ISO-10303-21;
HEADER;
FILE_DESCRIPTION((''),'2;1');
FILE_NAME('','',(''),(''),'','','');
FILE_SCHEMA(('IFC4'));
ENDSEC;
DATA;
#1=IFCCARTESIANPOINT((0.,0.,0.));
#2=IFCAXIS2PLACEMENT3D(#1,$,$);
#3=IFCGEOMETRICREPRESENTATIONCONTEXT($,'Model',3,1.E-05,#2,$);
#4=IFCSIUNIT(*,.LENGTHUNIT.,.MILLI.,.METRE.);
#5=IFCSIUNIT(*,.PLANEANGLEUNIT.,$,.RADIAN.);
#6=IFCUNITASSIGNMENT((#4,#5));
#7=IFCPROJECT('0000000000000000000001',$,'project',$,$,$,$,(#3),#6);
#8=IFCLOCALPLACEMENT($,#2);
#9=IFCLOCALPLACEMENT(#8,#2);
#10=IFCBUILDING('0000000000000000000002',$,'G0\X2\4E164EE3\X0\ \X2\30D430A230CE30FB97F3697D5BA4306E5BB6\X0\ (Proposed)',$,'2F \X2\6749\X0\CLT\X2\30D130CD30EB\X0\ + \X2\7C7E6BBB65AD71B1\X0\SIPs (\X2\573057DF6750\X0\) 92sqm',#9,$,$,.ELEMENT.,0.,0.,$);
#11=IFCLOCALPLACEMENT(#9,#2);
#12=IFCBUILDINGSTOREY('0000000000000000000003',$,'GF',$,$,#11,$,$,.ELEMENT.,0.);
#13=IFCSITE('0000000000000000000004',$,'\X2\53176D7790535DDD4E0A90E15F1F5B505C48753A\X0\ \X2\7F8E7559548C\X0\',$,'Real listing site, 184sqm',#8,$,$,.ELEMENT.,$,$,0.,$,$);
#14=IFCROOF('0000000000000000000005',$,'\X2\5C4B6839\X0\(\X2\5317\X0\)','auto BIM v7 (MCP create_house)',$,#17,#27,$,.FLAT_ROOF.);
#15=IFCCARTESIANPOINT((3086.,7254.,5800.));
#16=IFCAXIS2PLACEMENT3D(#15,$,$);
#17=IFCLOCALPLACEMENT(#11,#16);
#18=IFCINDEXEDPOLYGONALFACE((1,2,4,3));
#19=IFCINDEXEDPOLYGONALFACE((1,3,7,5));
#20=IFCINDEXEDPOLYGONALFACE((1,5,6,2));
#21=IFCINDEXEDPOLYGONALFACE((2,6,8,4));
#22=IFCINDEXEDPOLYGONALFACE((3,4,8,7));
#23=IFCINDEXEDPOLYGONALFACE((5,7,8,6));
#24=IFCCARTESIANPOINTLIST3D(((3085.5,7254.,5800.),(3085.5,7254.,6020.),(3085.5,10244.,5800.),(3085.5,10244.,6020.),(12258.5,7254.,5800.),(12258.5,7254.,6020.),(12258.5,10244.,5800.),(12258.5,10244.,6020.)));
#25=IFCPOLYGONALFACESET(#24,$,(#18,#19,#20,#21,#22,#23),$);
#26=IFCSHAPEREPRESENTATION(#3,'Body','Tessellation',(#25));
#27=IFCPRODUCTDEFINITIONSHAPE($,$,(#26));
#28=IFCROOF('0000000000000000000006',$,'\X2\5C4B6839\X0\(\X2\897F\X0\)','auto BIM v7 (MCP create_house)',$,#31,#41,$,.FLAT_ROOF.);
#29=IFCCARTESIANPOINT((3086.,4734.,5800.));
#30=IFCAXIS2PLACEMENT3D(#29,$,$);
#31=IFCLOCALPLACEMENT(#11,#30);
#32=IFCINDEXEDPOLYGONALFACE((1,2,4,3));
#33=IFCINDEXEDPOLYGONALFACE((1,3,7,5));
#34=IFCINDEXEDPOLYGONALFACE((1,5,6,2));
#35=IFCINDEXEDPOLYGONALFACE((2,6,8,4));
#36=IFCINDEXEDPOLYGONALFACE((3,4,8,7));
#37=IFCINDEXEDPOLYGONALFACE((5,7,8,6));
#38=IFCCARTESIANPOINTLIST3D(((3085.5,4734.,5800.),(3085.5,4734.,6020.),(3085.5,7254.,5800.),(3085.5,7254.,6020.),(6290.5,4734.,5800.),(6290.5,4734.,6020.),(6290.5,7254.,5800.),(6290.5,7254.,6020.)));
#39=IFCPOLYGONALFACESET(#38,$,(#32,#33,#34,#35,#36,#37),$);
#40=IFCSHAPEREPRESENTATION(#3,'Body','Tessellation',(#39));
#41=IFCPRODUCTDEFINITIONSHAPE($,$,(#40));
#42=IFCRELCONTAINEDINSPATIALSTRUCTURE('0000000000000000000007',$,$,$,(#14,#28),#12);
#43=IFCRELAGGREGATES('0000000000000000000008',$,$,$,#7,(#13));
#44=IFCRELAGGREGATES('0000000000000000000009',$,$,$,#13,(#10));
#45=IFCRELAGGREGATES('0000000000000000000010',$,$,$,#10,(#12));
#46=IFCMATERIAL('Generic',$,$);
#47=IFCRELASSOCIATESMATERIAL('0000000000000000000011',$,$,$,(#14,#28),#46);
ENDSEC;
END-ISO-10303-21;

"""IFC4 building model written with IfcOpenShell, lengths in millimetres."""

from ifc_helpers import new_model, si_unit, frame, frame_2d, origin, place, context, project, spatial, rectangle, extrude, material, element, save


model = new_model("IFC4")

# Units and contexts
model_context = context("Model", 3, precision=1e-05, world=origin())
ifc_project = project(units=[si_unit("LENGTHUNIT", "METRE", prefix="MILLI"), si_unit("PLANEANGLEUNIT", "RADIAN")], contexts=[model_context])

# Site, building, storey
site_placement = place(None, origin())
site = spatial("IfcSite", under=ifc_project, at=site_placement, Name="北海道川上郡弟子屈町 美留和", ObjectType="Real listing site, 184sqm", CompositionType="ELEMENT", RefElevation=0.0)
building_placement = place(site_placement, origin())
building = spatial("IfcBuilding", under=site, at=building_placement, Name="G0世代 ピアノ・音楽室の家 (Proposed)", ObjectType="2F 杉CLTパネル + 籾殻断熱SIPs (地域材) 92sqm", CompositionType="ELEMENT", ElevationOfRefHeight=0.0, ElevationOfTerrain=0.0)
storey_placement = place(building_placement, origin())
storey = spatial("IfcBuildingStorey", under=building, at=storey_placement, Name="GF", CompositionType="ELEMENT", Elevation=0.0)

# Shared definitions
ifc_material = material(Name="Generic")

# Roofs
roof_1_placement = place(storey_placement, frame((3086.0, 7254.0, 5800.0)))
element("IfcRoof", 1, at=roof_1_placement, inside=storey, material=ifc_material, Name="屋根(北)", Description="auto BIM v7 (MCP create_house)", PredefinedType="FLAT_ROOF", context=model_context, shape_type="SweptSolid", body=[
    extrude(rectangle(XDim=9173.0, YDim=2990.0, at=frame_2d((4586.0, 1495.0))), frame((3086.0, 7254.0, 5800.0)), (0.0, 0.0, 1.0), 220.0),
])
roof_2_placement = place(storey_placement, frame((3086.0, 4734.0, 5800.0)))
element("IfcRoof", 2, at=roof_2_placement, inside=storey, material=ifc_material, Name="屋根(西)", Description="auto BIM v7 (MCP create_house)", PredefinedType="FLAT_ROOF", context=model_context, shape_type="SweptSolid", body=[
    extrude(rectangle(XDim=3205.0, YDim=2520.0, at=frame_2d((1602.0, 1260.0))), frame((3086.0, 4734.0, 5800.0)), (0.0, 0.0, 1.0), 220.0),
])

save(model, "model.ifc")
